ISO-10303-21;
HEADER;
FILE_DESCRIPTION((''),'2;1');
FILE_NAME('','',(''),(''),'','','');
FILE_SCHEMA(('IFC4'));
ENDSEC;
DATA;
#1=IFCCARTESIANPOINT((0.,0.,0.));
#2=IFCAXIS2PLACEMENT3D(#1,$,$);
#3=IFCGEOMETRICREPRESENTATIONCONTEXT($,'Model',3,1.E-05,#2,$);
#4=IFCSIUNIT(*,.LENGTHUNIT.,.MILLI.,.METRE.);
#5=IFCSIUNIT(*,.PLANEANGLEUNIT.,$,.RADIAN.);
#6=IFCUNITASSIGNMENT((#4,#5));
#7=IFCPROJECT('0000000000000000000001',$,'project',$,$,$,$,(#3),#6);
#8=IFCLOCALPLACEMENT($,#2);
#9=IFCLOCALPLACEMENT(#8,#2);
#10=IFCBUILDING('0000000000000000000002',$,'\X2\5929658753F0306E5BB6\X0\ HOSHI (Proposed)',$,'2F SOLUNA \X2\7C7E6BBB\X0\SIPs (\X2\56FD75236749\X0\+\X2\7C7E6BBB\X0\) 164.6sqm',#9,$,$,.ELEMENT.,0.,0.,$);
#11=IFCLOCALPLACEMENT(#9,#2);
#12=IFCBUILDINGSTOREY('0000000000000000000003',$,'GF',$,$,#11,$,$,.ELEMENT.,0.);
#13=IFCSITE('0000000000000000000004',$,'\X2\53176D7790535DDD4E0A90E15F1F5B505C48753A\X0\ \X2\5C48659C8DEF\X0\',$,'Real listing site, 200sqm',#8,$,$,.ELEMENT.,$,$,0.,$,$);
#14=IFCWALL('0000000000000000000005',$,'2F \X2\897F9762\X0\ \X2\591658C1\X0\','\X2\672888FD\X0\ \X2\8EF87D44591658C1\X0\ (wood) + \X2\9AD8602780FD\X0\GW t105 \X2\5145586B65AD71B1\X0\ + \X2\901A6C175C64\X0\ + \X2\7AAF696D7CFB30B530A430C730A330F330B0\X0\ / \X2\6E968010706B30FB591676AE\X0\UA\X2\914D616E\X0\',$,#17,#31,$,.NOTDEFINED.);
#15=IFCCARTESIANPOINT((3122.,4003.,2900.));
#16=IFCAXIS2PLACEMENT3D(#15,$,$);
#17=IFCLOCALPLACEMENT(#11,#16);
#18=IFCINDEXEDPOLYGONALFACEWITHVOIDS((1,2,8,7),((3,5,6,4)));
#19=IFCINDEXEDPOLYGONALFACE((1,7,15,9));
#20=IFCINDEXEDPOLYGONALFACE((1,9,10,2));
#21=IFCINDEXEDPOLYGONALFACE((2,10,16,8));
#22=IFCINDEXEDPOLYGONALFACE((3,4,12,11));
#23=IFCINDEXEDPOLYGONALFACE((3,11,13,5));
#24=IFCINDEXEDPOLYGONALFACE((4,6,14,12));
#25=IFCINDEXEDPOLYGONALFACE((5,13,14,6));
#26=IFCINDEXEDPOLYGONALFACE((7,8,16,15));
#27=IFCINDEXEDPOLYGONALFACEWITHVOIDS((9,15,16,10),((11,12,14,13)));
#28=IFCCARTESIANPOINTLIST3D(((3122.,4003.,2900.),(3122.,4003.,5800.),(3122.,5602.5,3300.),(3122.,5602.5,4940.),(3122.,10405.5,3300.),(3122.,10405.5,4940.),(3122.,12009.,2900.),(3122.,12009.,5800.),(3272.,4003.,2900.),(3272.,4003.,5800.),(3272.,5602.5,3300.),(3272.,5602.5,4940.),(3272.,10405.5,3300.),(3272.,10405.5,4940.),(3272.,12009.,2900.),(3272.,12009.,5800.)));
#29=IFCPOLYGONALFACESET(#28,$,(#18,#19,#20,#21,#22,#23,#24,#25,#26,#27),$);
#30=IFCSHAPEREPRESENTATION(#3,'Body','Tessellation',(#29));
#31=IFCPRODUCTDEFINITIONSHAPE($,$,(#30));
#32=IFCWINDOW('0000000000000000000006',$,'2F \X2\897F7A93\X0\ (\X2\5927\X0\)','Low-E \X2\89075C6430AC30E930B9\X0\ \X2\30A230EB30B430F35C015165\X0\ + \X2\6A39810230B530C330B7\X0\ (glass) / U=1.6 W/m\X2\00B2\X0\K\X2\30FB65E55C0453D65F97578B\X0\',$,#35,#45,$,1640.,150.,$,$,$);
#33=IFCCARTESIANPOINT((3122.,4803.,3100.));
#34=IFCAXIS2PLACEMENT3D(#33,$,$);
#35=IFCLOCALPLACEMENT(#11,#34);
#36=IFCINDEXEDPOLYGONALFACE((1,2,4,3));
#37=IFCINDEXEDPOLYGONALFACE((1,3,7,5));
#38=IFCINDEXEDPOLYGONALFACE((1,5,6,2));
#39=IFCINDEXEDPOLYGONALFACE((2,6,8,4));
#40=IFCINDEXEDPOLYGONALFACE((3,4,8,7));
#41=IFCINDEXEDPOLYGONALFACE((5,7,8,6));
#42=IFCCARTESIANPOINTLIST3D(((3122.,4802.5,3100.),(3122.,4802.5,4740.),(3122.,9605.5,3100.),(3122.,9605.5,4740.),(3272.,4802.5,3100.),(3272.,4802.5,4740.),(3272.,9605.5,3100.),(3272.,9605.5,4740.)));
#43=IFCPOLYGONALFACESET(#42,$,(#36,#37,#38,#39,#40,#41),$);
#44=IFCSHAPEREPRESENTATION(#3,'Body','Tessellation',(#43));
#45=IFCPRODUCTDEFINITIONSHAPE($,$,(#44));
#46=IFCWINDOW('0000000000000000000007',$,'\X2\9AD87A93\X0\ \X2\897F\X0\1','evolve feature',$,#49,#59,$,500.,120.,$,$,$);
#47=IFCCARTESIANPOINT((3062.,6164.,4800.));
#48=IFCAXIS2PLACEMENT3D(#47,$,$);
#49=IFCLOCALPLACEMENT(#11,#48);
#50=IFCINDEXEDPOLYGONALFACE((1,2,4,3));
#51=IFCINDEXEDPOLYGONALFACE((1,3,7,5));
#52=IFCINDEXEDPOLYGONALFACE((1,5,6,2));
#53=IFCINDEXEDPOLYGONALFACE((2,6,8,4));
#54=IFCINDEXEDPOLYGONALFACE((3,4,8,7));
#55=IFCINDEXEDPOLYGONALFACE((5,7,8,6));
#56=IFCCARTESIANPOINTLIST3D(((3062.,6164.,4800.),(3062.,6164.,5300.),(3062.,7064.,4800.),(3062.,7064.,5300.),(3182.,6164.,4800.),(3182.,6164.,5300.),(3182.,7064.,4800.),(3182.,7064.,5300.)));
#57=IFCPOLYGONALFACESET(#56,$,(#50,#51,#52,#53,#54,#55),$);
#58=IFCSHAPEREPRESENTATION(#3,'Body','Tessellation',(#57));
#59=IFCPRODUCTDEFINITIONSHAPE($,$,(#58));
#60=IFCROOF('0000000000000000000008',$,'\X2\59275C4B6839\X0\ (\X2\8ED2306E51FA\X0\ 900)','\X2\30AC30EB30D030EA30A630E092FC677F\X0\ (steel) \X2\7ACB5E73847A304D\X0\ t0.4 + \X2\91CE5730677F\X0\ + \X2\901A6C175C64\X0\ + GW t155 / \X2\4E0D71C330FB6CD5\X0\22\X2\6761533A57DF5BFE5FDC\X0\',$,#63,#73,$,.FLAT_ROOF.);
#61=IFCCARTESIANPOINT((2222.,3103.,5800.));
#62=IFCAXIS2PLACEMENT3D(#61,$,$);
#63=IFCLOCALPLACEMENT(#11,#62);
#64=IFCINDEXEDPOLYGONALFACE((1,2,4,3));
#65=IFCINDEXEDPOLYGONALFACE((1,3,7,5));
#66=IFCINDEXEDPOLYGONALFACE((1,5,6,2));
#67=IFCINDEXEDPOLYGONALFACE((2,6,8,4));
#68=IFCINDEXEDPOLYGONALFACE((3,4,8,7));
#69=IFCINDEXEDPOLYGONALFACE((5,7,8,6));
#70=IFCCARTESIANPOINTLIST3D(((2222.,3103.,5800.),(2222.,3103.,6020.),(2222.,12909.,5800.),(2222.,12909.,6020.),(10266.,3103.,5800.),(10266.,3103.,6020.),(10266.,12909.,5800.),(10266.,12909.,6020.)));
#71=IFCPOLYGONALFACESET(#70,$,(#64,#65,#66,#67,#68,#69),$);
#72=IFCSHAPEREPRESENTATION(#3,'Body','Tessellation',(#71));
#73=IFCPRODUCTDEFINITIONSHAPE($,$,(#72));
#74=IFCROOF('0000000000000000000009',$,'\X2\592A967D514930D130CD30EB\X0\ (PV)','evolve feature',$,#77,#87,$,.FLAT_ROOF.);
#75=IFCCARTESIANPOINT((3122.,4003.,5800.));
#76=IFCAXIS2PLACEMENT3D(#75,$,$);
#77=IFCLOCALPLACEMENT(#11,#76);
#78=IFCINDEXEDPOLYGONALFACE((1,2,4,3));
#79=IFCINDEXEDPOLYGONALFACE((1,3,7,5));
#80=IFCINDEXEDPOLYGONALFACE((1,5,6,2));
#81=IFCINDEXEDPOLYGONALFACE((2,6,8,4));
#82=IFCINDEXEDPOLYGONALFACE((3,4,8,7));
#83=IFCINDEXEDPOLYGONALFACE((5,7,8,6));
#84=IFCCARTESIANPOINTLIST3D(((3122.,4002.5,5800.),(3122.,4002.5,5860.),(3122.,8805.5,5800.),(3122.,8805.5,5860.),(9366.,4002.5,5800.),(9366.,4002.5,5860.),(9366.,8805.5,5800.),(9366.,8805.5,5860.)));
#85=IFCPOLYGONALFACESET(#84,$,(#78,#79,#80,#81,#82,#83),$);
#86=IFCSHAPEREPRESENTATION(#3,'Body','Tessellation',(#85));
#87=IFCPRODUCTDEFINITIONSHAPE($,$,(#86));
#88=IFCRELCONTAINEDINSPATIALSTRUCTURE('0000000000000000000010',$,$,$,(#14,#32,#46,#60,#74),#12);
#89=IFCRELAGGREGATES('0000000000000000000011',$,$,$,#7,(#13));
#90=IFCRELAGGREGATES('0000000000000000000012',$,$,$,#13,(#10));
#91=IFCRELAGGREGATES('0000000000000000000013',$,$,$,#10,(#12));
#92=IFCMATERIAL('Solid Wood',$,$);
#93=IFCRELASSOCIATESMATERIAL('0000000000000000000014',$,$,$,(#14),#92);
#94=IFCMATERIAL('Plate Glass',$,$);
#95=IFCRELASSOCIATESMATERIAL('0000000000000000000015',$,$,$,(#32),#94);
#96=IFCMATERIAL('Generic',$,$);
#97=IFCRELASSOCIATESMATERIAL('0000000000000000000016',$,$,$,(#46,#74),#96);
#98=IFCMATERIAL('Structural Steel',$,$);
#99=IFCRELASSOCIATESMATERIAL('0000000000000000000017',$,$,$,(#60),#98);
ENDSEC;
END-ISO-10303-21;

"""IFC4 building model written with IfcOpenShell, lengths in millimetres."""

from ifc_helpers import new_model, si_unit, frame, frame_2d, origin, place, context, project, spatial, rectangle, extrude, material, element, fill, save


model = new_model("IFC4")

# Units and contexts
model_context = context("Model", 3, precision=1e-05, world=origin())
ifc_project = project(units=[si_unit("LENGTHUNIT", "METRE", prefix="MILLI"), si_unit("PLANEANGLEUNIT", "RADIAN")], contexts=[model_context])

# Site, building, storey
site_placement = place(None, origin())
site = spatial("IfcSite", under=ifc_project, at=site_placement, Name="北海道川上郡弟子屈町 屈斜路", ObjectType="Real listing site, 200sqm", CompositionType="ELEMENT", RefElevation=0.0)
building_placement = place(site_placement, origin())
building = spatial("IfcBuilding", under=site, at=building_placement, Name="天文台の家 HOSHI (Proposed)", ObjectType="2F SOLUNA 籾殻SIPs (国産杉+籾殻) 164.6sqm", CompositionType="ELEMENT", ElevationOfRefHeight=0.0, ElevationOfTerrain=0.0)
storey_placement = place(building_placement, origin())
storey = spatial("IfcBuildingStorey", under=building, at=storey_placement, Name="GF", CompositionType="ELEMENT", Elevation=0.0)

# Shared definitions
ifc_material_1 = material(Name="Solid Wood")
ifc_material_2 = material(Name="Generic")

# Shared definitions
ifc_material_3 = material(Name="Plate Glass")

# Wall, openings, windows
wall_1_placement = place(storey_placement, frame((3122.0, 4003.0, 2900.0)))
wall_1 = element("IfcWall", 1, at=wall_1_placement, inside=storey, material=ifc_material_1, Name="2F 西面 外壁", Description="木製 軸組外壁 (wood) + 高性能GW t105 充填断熱 + 通気層 + 窯業系サイディング / 準耐火・外皮UA配慮", PredefinedType="NOTDEFINED", context=model_context, shape_type="SweptSolid", body=[
    extrude(rectangle(XDim=150.0, YDim=8006.0, at=frame_2d((75.0, 4003.0))), frame((3122.0, 4003.0, 2900.0)), (0.0, 0.0, 1.0), 2900.0),
])
opening_1_placement = place(storey_placement, frame((3122.0, 4803.0, 3100.0)))
opening_1 = element("IfcOpeningElement", 2, at=opening_1_placement, cuts=wall_1, PredefinedType="NOTDEFINED", context=model_context, shape_type="SweptSolid", body=[
    extrude(rectangle(XDim=150.0, YDim=4803.0, at=frame_2d((75.0, 2401.0))), frame((3122.0, 4803.0, 3100.0)), (0.0, 0.0, 1.0), 1640.0),
])
opening_2_placement = place(storey_placement, frame((3062.0, 6164.0, 4800.0)))
opening_2 = element("IfcOpeningElement", 3, at=opening_2_placement, cuts=wall_1, PredefinedType="NOTDEFINED", context=model_context, shape_type="SweptSolid", body=[
    extrude(rectangle(XDim=120.0, YDim=900.0, at=frame_2d((60.0, 450.0))), frame((3062.0, 6164.0, 4800.0)), (0.0, 0.0, 1.0), 500.0),
])
window_1_placement = place(storey_placement, frame((3122.0, 4803.0, 3100.0)))
window_1 = element("IfcWindow", 4, at=window_1_placement, inside=storey, material=ifc_material_3, Name="2F 西窓 (大)", Description="Low-E 複層ガラス アルゴン封入 + 樹脂サッシ (glass) / U=1.6 W/m²K・日射取得型", OverallHeight=1640.0, OverallWidth=150.0, context=model_context, shape_type="SweptSolid", body=[
    extrude(rectangle(XDim=150.0, YDim=4803.0, at=frame_2d((75.0, 2401.0))), frame((3122.0, 4803.0, 3100.0)), (0.0, 0.0, 1.0), 1640.0),
])
fill(opening_1, window_1)
window_2_placement = place(storey_placement, frame((3062.0, 6164.0, 4800.0)))
window_2 = element("IfcWindow", 5, at=window_2_placement, inside=storey, material=ifc_material_2, Name="高窓 西1", Description="evolve feature", OverallHeight=500.0, OverallWidth=120.0, context=model_context, shape_type="SweptSolid", body=[
    extrude(rectangle(XDim=120.0, YDim=900.0, at=frame_2d((60.0, 450.0))), frame((3062.0, 6164.0, 4800.0)), (0.0, 0.0, 1.0), 500.0),
])
fill(opening_2, window_2)

# Roofs
ifc_material_4 = material(Name="Structural Steel")
roof_1_placement = place(storey_placement, frame((2222.0, 3103.0, 5800.0)))
element("IfcRoof", 6, at=roof_1_placement, inside=storey, material=ifc_material_4, Name="大屋根 (軒の出 900)", Description="ガルバリウム鋼板 (steel) 立平葺き t0.4 + 野地板 + 通気層 + GW t155 / 不燃・法22条区域対応", PredefinedType="FLAT_ROOF", context=model_context, shape_type="SweptSolid", body=[
    extrude(rectangle(XDim=8044.0, YDim=9806.0, at=frame_2d((4022.0, 4903.0))), frame((2222.0, 3103.0, 5800.0)), (0.0, 0.0, 1.0), 220.0),
])
roof_2_placement = place(storey_placement, frame((3122.0, 4003.0, 5800.0)))
element("IfcRoof", 7, at=roof_2_placement, inside=storey, material=ifc_material_2, Name="太陽光パネル (PV)", Description="evolve feature", PredefinedType="FLAT_ROOF", context=model_context, shape_type="SweptSolid", body=[
    extrude(rectangle(XDim=6244.0, YDim=4803.0, at=frame_2d((3122.0, 2401.0))), frame((3122.0, 4003.0, 5800.0)), (0.0, 0.0, 1.0), 60.0),
])

save(model, "model.ifc")
